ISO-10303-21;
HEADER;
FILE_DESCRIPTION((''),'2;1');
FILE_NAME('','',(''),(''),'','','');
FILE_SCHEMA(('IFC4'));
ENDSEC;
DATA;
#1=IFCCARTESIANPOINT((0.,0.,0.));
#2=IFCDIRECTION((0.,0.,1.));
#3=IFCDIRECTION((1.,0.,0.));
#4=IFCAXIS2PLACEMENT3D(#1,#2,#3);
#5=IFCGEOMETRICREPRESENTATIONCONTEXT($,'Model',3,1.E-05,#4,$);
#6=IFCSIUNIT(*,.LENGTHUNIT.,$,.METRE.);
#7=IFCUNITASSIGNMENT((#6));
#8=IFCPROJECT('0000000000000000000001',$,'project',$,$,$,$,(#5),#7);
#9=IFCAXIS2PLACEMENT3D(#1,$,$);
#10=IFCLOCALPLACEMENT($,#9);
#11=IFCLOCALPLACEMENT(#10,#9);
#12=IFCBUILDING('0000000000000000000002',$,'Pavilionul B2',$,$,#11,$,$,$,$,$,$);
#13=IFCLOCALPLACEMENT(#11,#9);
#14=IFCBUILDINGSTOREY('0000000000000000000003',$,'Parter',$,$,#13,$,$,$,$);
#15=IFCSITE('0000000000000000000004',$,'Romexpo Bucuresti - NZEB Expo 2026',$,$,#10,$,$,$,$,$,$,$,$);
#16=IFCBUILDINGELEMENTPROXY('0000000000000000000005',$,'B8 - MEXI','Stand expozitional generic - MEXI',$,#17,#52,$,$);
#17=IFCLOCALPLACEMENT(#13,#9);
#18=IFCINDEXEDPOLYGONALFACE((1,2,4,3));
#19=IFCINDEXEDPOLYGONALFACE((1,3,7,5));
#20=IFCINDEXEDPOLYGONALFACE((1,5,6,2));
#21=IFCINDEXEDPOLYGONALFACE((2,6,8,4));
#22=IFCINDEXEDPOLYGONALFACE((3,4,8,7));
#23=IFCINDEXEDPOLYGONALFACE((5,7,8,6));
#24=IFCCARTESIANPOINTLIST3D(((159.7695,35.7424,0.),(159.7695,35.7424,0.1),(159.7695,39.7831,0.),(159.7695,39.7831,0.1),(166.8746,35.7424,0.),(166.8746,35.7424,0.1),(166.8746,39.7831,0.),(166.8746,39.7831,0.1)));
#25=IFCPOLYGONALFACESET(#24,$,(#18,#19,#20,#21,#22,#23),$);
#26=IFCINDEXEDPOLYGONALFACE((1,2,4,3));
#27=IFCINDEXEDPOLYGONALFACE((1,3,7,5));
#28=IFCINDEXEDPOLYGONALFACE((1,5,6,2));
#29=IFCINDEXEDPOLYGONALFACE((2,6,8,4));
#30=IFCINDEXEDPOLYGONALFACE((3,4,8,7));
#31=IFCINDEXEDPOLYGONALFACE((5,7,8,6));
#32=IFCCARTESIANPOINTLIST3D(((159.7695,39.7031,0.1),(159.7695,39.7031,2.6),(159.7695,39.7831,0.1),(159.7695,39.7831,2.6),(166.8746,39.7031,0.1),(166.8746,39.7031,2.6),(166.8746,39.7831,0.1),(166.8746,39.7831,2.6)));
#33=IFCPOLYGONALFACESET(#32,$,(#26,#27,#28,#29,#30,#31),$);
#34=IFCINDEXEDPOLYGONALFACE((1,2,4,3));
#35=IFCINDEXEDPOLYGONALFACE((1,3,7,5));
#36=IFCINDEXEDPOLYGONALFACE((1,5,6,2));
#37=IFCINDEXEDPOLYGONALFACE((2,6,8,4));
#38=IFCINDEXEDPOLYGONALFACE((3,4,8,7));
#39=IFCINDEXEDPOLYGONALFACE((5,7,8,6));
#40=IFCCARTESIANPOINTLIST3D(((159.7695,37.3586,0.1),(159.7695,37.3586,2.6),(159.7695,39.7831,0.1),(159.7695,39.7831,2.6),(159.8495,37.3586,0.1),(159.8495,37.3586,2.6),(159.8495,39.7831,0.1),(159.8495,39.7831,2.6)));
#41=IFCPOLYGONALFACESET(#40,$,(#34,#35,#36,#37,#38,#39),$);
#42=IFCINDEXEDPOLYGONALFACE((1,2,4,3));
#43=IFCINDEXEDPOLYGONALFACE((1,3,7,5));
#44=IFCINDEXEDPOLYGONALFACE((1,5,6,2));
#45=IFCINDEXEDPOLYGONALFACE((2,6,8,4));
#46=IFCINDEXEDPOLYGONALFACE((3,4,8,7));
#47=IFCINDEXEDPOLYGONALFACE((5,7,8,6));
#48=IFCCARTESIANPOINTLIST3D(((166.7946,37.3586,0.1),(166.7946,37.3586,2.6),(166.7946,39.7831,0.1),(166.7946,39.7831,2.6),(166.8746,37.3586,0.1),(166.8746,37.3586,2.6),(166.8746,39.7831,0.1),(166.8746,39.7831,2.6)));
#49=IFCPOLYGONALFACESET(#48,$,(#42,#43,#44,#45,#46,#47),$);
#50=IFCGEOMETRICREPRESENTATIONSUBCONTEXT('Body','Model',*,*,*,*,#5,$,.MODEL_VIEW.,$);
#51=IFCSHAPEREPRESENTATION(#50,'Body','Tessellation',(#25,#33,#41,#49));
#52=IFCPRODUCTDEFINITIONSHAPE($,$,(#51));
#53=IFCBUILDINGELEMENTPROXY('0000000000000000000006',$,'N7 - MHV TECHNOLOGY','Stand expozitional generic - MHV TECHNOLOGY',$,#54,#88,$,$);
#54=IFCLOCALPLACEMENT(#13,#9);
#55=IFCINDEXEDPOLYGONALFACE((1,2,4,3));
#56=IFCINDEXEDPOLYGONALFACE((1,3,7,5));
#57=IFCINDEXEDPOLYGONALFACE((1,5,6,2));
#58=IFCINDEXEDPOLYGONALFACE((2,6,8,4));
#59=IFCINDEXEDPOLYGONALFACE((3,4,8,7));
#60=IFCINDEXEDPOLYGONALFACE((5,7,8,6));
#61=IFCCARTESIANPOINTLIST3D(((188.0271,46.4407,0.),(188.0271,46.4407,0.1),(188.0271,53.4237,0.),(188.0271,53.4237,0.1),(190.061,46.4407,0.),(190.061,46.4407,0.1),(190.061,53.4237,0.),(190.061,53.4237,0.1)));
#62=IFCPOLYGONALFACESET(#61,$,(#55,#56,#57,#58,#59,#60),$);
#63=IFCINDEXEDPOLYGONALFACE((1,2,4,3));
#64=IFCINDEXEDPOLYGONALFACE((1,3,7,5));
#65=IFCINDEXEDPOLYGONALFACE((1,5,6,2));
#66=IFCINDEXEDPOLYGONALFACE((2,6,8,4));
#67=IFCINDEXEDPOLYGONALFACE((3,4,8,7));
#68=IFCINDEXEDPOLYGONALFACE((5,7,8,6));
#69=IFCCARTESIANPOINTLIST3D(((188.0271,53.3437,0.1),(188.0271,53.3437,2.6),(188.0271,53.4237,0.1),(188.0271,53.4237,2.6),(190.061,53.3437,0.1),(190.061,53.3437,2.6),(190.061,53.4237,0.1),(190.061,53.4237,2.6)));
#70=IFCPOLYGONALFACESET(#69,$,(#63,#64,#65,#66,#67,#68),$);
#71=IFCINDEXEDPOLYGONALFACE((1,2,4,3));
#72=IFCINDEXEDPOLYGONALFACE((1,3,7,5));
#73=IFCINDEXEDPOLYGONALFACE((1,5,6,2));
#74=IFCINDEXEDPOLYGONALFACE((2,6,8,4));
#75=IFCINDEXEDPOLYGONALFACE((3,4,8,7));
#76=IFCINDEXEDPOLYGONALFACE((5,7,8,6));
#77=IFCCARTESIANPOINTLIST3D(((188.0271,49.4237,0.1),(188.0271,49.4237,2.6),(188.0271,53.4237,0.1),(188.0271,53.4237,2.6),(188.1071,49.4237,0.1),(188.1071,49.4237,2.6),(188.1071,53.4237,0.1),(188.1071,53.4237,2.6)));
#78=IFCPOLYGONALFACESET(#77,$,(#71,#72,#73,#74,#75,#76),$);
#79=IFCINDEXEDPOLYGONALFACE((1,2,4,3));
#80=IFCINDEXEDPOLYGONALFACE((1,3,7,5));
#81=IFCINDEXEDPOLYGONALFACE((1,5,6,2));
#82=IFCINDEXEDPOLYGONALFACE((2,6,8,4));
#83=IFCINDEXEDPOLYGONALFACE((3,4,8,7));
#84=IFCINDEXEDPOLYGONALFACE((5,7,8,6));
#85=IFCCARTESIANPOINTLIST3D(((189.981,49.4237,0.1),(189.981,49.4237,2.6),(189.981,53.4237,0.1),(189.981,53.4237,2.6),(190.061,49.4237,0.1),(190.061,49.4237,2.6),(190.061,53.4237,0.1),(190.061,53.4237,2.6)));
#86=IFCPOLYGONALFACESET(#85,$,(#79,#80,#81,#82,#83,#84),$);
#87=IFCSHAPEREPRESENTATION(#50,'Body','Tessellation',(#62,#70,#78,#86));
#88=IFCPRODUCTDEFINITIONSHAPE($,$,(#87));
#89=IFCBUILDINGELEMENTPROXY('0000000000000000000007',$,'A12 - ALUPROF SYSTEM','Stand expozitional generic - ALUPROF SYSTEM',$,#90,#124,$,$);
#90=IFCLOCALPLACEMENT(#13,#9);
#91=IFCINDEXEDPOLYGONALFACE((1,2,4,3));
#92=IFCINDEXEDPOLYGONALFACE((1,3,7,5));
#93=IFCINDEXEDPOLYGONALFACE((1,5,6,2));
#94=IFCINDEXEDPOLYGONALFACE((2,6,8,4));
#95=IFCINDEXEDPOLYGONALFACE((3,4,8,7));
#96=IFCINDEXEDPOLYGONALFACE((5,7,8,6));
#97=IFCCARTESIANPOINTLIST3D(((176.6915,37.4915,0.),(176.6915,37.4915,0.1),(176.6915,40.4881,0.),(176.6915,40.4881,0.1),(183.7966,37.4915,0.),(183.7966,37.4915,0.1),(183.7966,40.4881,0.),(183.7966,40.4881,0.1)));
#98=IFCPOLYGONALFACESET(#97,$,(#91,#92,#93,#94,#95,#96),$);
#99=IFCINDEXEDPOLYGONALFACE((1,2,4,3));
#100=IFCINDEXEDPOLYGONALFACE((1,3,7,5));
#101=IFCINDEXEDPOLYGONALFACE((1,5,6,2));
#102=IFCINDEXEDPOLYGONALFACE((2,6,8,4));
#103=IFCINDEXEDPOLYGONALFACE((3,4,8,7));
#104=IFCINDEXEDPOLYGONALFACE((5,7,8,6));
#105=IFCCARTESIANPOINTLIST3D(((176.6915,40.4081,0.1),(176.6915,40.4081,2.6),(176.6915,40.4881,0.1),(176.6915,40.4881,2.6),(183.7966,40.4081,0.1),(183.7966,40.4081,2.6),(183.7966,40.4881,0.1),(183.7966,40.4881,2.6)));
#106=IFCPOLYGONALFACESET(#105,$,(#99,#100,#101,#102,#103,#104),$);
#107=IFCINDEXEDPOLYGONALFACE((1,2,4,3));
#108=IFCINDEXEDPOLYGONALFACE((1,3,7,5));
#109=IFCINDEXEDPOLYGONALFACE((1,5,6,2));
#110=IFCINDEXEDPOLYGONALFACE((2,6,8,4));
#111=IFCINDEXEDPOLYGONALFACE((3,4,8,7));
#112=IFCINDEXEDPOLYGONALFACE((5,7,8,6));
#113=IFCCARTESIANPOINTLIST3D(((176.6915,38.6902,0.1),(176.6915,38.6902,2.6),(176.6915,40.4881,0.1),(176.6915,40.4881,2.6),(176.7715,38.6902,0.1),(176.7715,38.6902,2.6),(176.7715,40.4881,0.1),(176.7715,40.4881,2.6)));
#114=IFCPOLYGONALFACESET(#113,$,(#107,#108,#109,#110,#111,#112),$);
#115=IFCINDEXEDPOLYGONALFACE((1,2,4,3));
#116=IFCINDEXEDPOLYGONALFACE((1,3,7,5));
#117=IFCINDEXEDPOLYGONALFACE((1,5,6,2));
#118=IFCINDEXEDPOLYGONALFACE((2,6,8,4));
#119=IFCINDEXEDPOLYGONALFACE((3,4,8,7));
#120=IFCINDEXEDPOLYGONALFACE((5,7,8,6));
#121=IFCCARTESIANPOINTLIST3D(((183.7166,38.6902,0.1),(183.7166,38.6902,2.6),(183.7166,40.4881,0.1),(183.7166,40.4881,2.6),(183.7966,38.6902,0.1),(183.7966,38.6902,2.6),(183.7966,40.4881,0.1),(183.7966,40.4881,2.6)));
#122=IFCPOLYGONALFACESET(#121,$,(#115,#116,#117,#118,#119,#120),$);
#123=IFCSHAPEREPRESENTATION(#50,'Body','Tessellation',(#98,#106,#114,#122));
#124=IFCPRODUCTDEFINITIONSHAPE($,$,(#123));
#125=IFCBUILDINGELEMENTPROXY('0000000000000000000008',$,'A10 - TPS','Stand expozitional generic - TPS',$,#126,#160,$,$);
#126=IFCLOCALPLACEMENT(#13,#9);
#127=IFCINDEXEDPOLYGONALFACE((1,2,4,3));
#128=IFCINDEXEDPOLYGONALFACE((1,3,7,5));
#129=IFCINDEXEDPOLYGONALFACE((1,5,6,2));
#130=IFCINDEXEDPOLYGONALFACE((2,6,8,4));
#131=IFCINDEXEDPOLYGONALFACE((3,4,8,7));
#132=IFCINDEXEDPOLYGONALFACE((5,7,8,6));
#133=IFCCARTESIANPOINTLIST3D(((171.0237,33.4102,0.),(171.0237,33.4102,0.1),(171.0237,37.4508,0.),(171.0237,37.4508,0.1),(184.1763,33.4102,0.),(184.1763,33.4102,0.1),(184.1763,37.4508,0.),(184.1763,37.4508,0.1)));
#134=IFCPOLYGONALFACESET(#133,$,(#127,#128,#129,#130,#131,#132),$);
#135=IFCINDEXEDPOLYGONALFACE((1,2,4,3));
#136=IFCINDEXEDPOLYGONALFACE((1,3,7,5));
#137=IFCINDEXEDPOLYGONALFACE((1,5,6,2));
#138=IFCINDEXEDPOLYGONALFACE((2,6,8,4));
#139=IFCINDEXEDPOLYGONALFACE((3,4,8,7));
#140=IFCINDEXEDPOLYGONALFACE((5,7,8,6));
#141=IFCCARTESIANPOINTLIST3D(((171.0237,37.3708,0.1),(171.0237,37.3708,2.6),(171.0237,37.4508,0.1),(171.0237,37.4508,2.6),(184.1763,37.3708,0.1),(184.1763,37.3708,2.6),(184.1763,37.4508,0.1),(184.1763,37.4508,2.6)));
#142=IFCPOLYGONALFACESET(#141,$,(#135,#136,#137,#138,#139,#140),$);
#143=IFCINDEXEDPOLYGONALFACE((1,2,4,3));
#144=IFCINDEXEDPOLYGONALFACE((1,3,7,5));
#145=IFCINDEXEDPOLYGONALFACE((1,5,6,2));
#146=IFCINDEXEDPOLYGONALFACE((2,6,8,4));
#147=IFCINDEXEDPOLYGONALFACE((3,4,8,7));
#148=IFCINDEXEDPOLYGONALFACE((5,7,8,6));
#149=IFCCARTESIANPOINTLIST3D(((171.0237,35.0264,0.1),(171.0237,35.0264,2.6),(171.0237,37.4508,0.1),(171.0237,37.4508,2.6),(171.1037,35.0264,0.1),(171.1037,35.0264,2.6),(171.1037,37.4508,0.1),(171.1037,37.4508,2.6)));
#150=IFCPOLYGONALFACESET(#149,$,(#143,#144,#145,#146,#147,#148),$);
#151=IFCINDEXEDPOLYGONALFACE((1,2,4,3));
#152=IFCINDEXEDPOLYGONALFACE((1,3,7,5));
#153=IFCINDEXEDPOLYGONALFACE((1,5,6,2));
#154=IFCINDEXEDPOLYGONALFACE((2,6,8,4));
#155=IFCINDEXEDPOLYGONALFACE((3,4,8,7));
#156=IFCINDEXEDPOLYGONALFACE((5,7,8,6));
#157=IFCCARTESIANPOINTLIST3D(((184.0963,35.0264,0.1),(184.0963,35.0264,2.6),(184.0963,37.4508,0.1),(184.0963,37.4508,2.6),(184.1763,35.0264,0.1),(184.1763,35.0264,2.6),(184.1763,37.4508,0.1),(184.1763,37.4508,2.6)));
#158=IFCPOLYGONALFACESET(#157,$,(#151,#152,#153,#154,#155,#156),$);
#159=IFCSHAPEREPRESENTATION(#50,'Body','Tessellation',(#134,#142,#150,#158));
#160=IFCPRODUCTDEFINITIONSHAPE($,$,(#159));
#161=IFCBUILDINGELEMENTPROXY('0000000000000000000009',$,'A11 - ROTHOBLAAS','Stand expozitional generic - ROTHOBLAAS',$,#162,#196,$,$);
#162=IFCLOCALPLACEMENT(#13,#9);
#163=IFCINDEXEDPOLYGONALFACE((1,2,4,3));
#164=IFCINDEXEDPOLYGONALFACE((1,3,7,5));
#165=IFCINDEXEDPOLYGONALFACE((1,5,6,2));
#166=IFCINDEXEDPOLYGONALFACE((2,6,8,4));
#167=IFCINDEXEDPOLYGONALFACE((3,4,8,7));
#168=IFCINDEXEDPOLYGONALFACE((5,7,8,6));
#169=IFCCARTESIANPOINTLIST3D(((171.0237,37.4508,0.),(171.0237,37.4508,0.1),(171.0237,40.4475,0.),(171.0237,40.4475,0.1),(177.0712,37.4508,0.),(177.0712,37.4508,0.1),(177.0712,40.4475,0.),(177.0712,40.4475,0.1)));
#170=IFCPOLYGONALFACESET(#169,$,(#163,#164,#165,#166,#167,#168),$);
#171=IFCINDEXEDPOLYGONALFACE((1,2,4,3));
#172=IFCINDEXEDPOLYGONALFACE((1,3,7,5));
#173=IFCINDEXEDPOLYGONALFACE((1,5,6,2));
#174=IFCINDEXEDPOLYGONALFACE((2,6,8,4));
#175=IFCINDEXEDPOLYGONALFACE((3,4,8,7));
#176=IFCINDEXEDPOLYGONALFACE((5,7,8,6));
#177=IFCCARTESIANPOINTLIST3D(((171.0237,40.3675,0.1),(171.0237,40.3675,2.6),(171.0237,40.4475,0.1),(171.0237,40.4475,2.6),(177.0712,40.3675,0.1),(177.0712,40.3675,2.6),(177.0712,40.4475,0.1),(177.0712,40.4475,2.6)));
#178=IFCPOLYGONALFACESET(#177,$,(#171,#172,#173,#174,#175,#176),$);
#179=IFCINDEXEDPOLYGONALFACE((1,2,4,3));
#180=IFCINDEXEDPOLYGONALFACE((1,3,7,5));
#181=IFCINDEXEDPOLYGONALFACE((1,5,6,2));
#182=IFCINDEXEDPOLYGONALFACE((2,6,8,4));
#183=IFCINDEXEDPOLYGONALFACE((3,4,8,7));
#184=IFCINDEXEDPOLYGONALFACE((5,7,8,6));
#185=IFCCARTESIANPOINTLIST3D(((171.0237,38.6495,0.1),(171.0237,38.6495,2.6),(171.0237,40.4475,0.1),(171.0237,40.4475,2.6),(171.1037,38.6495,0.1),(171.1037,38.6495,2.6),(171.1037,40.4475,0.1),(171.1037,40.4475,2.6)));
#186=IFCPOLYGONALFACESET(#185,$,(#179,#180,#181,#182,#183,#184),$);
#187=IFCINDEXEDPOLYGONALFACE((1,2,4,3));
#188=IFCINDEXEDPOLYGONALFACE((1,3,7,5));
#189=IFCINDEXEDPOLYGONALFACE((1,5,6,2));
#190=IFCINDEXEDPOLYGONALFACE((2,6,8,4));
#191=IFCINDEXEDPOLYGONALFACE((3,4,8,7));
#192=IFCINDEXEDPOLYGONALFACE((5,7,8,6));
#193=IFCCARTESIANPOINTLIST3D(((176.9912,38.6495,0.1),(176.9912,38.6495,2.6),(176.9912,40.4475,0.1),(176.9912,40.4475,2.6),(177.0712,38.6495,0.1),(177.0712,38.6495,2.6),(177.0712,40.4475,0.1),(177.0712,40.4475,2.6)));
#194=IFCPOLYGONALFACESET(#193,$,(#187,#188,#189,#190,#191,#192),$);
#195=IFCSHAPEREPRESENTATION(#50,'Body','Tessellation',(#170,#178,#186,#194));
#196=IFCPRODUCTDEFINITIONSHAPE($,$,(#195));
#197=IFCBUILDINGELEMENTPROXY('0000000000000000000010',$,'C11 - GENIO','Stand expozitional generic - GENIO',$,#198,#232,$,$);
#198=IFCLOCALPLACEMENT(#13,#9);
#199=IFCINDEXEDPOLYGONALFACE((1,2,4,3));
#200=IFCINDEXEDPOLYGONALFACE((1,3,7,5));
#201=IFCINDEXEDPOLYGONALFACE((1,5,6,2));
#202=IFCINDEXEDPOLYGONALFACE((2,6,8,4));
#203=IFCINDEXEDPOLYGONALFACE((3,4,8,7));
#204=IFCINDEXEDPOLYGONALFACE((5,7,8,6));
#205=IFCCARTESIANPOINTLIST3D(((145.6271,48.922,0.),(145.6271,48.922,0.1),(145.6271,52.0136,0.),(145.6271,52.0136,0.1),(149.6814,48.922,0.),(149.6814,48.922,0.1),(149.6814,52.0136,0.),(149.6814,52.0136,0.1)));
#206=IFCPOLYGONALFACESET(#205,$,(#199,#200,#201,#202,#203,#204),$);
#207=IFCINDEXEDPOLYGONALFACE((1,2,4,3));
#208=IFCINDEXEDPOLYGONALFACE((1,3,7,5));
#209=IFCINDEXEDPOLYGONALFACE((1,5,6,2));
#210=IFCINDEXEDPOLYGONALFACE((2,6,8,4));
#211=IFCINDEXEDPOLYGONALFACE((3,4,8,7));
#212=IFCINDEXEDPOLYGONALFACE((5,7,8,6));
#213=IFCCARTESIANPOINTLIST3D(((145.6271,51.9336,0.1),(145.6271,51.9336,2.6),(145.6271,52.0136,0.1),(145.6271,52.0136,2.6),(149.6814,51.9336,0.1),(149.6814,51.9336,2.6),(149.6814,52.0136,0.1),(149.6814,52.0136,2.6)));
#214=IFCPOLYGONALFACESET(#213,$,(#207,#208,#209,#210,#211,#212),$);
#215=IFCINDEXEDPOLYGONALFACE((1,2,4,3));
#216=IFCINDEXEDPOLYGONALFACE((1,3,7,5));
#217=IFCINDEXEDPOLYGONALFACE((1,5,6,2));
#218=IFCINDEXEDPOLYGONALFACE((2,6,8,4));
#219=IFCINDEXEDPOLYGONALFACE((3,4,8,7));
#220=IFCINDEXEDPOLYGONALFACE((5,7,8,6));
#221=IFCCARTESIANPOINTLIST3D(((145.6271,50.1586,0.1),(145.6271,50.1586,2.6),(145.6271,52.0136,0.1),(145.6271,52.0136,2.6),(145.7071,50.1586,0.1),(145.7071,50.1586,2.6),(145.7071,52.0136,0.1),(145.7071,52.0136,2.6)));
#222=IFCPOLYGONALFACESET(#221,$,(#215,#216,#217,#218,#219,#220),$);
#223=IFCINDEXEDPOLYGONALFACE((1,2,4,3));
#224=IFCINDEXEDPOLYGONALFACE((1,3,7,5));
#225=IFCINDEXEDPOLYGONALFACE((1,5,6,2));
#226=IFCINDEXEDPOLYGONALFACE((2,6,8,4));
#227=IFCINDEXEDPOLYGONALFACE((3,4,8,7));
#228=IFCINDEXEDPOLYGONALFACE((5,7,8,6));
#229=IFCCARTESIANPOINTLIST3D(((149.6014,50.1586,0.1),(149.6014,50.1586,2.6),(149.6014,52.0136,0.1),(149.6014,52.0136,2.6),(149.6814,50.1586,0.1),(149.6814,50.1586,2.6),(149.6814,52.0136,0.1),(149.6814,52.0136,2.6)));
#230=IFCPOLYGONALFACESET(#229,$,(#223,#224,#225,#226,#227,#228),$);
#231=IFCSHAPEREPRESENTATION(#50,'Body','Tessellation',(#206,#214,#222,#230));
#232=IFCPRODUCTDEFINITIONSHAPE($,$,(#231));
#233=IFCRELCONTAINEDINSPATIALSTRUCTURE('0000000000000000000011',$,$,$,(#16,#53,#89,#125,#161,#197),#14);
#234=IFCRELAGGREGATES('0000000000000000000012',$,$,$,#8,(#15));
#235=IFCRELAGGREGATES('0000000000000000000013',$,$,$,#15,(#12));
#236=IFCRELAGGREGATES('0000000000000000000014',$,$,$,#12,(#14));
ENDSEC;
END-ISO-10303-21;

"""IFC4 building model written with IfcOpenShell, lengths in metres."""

from ifc_helpers import new_model, si_unit, frame, frame_2d, origin, origin_with_axes, place, context, subcontext, project, spatial, rectangle, extrude, element, save


model = new_model("IFC4")

# Units and contexts
model_context = context("Model", 3, precision=1e-05, world=origin_with_axes())
body_context = subcontext(model_context, "Body", "Model", "MODEL_VIEW")
ifc_project = project(units=[si_unit("LENGTHUNIT", "METRE")], contexts=[model_context])

# Site, building, storey
site_placement = place(None, origin())
site = spatial("IfcSite", under=ifc_project, at=site_placement, Name="Romexpo Bucuresti - NZEB Expo 2026")
building_placement = place(site_placement, origin())
building = spatial("IfcBuilding", under=site, at=building_placement, Name="Pavilionul B2")
storey_placement = place(building_placement, origin())
storey = spatial("IfcBuildingStorey", under=building, at=storey_placement, Name="Parter")

# Building element proxies
proxy_1_placement = place(storey_placement, frame((159.7695, 35.7424, 0.0), z_axis=(0.0, 0.0, 1.0), x_axis=(1.0, 0.0, 0.0)))
element("IfcBuildingElementProxy", 1, at=proxy_1_placement, inside=storey, Name="B8 - MEXI", Description="Stand expozitional generic - MEXI", context=body_context, shape_type="SweptSolid", body=[
    extrude(rectangle(XDim=7.1051, YDim=4.0407, at=frame_2d((3.5525, 2.0203))), origin(), (0.0, 0.0, 1.0), 0.1),
    extrude(rectangle(XDim=7.1051, YDim=0.08, at=frame_2d((3.5525, 4.0007))), frame((0.0, 0.0, 0.1)), (0.0, 0.0, 1.0), 2.5),
    extrude(rectangle(XDim=0.08, YDim=2.4244, at=frame_2d((0.04, 2.8285))), frame((0.0, 0.0, 0.1)), (0.0, 0.0, 1.0), 2.5),
    extrude(rectangle(XDim=0.08, YDim=2.4244, at=frame_2d((7.0651, 2.8285))), frame((0.0, 0.0, 0.1)), (0.0, 0.0, 1.0), 2.5),
])
proxy_2_placement = place(storey_placement, frame((188.0271, 46.4407, 0.0), z_axis=(0.0, 0.0, 1.0), x_axis=(1.0, 0.0, 0.0)))
element("IfcBuildingElementProxy", 2, at=proxy_2_placement, inside=storey, Name="N7 - MHV TECHNOLOGY", Description="Stand expozitional generic - MHV TECHNOLOGY", context=body_context, shape_type="SweptSolid", body=[
    extrude(rectangle(XDim=2.0339, YDim=6.9831, at=frame_2d((1.0169, 3.4915))), origin(), (0.0, 0.0, 1.0), 0.1),
    extrude(rectangle(XDim=2.0339, YDim=0.08, at=frame_2d((1.0169, 6.9431))), frame((0.0, 0.0, 0.1)), (0.0, 0.0, 1.0), 2.5),
    extrude(rectangle(XDim=0.08, YDim=4.0, at=frame_2d((0.04, 4.9831))), frame((0.0, 0.0, 0.1)), (0.0, 0.0, 1.0), 2.5),
    extrude(rectangle(XDim=0.08, YDim=4.0, at=frame_2d((1.9939, 4.9831))), frame((0.0, 0.0, 0.1)), (0.0, 0.0, 1.0), 2.5),
])
proxy_3_placement = place(storey_placement, frame((176.6915, 37.4915, 0.0), z_axis=(0.0, 0.0, 1.0), x_axis=(1.0, 0.0, 0.0)))
element("IfcBuildingElementProxy", 3, at=proxy_3_placement, inside=storey, Name="A12 - ALUPROF SYSTEM", Description="Stand expozitional generic - ALUPROF SYSTEM", context=body_context, shape_type="SweptSolid", body=[
    extrude(rectangle(XDim=7.1051, YDim=2.9966, at=frame_2d((3.5525, 1.4983))), origin(), (0.0, 0.0, 1.0), 0.1),
    extrude(rectangle(XDim=7.1051, YDim=0.08, at=frame_2d((3.5525, 2.9566))), frame((0.0, 0.0, 0.1)), (0.0, 0.0, 1.0), 2.5),
    extrude(rectangle(XDim=0.08, YDim=1.798, at=frame_2d((0.04, 2.0976))), frame((0.0, 0.0, 0.1)), (0.0, 0.0, 1.0), 2.5),
    extrude(rectangle(XDim=0.08, YDim=1.798, at=frame_2d((7.0651, 2.0976))), frame((0.0, 0.0, 0.1)), (0.0, 0.0, 1.0), 2.5),
])
proxy_4_placement = place(storey_placement, frame((171.0237, 33.4102, 0.0), z_axis=(0.0, 0.0, 1.0), x_axis=(1.0, 0.0, 0.0)))
element("IfcBuildingElementProxy", 4, at=proxy_4_placement, inside=storey, Name="A10 - TPS", Description="Stand expozitional generic - TPS", context=body_context, shape_type="SweptSolid", body=[
    extrude(rectangle(XDim=13.1525, YDim=4.0407, at=frame_2d((6.5763, 2.0203))), origin(), (0.0, 0.0, 1.0), 0.1),
    extrude(rectangle(XDim=13.1525, YDim=0.08, at=frame_2d((6.5763, 4.0007))), frame((0.0, 0.0, 0.1)), (0.0, 0.0, 1.0), 2.5),
    extrude(rectangle(XDim=0.08, YDim=2.4244, at=frame_2d((0.04, 2.8285))), frame((0.0, 0.0, 0.1)), (0.0, 0.0, 1.0), 2.5),
    extrude(rectangle(XDim=0.08, YDim=2.4244, at=frame_2d((13.1125, 2.8285))), frame((0.0, 0.0, 0.1)), (0.0, 0.0, 1.0), 2.5),
])
proxy_5_placement = place(storey_placement, frame((171.0237, 37.4508, 0.0), z_axis=(0.0, 0.0, 1.0), x_axis=(1.0, 0.0, 0.0)))
element("IfcBuildingElementProxy", 5, at=proxy_5_placement, inside=storey, Name="A11 - ROTHOBLAAS", Description="Stand expozitional generic - ROTHOBLAAS", context=body_context, shape_type="SweptSolid", body=[
    extrude(rectangle(XDim=6.0475, YDim=2.9966, at=frame_2d((3.0237, 1.4983))), origin(), (0.0, 0.0, 1.0), 0.1),
    extrude(rectangle(XDim=6.0475, YDim=0.08, at=frame_2d((3.0237, 2.9566))), frame((0.0, 0.0, 0.1)), (0.0, 0.0, 1.0), 2.5),
    extrude(rectangle(XDim=0.08, YDim=1.798, at=frame_2d((0.04, 2.0976))), frame((0.0, 0.0, 0.1)), (0.0, 0.0, 1.0), 2.5),
    extrude(rectangle(XDim=0.08, YDim=1.798, at=frame_2d((6.0075, 2.0976))), frame((0.0, 0.0, 0.1)), (0.0, 0.0, 1.0), 2.5),
])
proxy_6_placement = place(storey_placement, frame((145.6271, 48.922, 0.0), z_axis=(0.0, 0.0, 1.0), x_axis=(1.0, 0.0, 0.0)))
element("IfcBuildingElementProxy", 6, at=proxy_6_placement, inside=storey, Name="C11 - GENIO", Description="Stand expozitional generic - GENIO", context=body_context, shape_type="SweptSolid", body=[
    extrude(rectangle(XDim=4.0542, YDim=3.0915, at=frame_2d((2.0271, 1.5458))), origin(), (0.0, 0.0, 1.0), 0.1),
    extrude(rectangle(XDim=4.0542, YDim=0.08, at=frame_2d((2.0271, 3.0515))), frame((0.0, 0.0, 0.1)), (0.0, 0.0, 1.0), 2.5),
    extrude(rectangle(XDim=0.08, YDim=1.8549, at=frame_2d((0.04, 2.1641))), frame((0.0, 0.0, 0.1)), (0.0, 0.0, 1.0), 2.5),
    extrude(rectangle(XDim=0.08, YDim=1.8549, at=frame_2d((4.0142, 2.1641))), frame((0.0, 0.0, 0.1)), (0.0, 0.0, 1.0), 2.5),
])

save(model, "model.ifc")
